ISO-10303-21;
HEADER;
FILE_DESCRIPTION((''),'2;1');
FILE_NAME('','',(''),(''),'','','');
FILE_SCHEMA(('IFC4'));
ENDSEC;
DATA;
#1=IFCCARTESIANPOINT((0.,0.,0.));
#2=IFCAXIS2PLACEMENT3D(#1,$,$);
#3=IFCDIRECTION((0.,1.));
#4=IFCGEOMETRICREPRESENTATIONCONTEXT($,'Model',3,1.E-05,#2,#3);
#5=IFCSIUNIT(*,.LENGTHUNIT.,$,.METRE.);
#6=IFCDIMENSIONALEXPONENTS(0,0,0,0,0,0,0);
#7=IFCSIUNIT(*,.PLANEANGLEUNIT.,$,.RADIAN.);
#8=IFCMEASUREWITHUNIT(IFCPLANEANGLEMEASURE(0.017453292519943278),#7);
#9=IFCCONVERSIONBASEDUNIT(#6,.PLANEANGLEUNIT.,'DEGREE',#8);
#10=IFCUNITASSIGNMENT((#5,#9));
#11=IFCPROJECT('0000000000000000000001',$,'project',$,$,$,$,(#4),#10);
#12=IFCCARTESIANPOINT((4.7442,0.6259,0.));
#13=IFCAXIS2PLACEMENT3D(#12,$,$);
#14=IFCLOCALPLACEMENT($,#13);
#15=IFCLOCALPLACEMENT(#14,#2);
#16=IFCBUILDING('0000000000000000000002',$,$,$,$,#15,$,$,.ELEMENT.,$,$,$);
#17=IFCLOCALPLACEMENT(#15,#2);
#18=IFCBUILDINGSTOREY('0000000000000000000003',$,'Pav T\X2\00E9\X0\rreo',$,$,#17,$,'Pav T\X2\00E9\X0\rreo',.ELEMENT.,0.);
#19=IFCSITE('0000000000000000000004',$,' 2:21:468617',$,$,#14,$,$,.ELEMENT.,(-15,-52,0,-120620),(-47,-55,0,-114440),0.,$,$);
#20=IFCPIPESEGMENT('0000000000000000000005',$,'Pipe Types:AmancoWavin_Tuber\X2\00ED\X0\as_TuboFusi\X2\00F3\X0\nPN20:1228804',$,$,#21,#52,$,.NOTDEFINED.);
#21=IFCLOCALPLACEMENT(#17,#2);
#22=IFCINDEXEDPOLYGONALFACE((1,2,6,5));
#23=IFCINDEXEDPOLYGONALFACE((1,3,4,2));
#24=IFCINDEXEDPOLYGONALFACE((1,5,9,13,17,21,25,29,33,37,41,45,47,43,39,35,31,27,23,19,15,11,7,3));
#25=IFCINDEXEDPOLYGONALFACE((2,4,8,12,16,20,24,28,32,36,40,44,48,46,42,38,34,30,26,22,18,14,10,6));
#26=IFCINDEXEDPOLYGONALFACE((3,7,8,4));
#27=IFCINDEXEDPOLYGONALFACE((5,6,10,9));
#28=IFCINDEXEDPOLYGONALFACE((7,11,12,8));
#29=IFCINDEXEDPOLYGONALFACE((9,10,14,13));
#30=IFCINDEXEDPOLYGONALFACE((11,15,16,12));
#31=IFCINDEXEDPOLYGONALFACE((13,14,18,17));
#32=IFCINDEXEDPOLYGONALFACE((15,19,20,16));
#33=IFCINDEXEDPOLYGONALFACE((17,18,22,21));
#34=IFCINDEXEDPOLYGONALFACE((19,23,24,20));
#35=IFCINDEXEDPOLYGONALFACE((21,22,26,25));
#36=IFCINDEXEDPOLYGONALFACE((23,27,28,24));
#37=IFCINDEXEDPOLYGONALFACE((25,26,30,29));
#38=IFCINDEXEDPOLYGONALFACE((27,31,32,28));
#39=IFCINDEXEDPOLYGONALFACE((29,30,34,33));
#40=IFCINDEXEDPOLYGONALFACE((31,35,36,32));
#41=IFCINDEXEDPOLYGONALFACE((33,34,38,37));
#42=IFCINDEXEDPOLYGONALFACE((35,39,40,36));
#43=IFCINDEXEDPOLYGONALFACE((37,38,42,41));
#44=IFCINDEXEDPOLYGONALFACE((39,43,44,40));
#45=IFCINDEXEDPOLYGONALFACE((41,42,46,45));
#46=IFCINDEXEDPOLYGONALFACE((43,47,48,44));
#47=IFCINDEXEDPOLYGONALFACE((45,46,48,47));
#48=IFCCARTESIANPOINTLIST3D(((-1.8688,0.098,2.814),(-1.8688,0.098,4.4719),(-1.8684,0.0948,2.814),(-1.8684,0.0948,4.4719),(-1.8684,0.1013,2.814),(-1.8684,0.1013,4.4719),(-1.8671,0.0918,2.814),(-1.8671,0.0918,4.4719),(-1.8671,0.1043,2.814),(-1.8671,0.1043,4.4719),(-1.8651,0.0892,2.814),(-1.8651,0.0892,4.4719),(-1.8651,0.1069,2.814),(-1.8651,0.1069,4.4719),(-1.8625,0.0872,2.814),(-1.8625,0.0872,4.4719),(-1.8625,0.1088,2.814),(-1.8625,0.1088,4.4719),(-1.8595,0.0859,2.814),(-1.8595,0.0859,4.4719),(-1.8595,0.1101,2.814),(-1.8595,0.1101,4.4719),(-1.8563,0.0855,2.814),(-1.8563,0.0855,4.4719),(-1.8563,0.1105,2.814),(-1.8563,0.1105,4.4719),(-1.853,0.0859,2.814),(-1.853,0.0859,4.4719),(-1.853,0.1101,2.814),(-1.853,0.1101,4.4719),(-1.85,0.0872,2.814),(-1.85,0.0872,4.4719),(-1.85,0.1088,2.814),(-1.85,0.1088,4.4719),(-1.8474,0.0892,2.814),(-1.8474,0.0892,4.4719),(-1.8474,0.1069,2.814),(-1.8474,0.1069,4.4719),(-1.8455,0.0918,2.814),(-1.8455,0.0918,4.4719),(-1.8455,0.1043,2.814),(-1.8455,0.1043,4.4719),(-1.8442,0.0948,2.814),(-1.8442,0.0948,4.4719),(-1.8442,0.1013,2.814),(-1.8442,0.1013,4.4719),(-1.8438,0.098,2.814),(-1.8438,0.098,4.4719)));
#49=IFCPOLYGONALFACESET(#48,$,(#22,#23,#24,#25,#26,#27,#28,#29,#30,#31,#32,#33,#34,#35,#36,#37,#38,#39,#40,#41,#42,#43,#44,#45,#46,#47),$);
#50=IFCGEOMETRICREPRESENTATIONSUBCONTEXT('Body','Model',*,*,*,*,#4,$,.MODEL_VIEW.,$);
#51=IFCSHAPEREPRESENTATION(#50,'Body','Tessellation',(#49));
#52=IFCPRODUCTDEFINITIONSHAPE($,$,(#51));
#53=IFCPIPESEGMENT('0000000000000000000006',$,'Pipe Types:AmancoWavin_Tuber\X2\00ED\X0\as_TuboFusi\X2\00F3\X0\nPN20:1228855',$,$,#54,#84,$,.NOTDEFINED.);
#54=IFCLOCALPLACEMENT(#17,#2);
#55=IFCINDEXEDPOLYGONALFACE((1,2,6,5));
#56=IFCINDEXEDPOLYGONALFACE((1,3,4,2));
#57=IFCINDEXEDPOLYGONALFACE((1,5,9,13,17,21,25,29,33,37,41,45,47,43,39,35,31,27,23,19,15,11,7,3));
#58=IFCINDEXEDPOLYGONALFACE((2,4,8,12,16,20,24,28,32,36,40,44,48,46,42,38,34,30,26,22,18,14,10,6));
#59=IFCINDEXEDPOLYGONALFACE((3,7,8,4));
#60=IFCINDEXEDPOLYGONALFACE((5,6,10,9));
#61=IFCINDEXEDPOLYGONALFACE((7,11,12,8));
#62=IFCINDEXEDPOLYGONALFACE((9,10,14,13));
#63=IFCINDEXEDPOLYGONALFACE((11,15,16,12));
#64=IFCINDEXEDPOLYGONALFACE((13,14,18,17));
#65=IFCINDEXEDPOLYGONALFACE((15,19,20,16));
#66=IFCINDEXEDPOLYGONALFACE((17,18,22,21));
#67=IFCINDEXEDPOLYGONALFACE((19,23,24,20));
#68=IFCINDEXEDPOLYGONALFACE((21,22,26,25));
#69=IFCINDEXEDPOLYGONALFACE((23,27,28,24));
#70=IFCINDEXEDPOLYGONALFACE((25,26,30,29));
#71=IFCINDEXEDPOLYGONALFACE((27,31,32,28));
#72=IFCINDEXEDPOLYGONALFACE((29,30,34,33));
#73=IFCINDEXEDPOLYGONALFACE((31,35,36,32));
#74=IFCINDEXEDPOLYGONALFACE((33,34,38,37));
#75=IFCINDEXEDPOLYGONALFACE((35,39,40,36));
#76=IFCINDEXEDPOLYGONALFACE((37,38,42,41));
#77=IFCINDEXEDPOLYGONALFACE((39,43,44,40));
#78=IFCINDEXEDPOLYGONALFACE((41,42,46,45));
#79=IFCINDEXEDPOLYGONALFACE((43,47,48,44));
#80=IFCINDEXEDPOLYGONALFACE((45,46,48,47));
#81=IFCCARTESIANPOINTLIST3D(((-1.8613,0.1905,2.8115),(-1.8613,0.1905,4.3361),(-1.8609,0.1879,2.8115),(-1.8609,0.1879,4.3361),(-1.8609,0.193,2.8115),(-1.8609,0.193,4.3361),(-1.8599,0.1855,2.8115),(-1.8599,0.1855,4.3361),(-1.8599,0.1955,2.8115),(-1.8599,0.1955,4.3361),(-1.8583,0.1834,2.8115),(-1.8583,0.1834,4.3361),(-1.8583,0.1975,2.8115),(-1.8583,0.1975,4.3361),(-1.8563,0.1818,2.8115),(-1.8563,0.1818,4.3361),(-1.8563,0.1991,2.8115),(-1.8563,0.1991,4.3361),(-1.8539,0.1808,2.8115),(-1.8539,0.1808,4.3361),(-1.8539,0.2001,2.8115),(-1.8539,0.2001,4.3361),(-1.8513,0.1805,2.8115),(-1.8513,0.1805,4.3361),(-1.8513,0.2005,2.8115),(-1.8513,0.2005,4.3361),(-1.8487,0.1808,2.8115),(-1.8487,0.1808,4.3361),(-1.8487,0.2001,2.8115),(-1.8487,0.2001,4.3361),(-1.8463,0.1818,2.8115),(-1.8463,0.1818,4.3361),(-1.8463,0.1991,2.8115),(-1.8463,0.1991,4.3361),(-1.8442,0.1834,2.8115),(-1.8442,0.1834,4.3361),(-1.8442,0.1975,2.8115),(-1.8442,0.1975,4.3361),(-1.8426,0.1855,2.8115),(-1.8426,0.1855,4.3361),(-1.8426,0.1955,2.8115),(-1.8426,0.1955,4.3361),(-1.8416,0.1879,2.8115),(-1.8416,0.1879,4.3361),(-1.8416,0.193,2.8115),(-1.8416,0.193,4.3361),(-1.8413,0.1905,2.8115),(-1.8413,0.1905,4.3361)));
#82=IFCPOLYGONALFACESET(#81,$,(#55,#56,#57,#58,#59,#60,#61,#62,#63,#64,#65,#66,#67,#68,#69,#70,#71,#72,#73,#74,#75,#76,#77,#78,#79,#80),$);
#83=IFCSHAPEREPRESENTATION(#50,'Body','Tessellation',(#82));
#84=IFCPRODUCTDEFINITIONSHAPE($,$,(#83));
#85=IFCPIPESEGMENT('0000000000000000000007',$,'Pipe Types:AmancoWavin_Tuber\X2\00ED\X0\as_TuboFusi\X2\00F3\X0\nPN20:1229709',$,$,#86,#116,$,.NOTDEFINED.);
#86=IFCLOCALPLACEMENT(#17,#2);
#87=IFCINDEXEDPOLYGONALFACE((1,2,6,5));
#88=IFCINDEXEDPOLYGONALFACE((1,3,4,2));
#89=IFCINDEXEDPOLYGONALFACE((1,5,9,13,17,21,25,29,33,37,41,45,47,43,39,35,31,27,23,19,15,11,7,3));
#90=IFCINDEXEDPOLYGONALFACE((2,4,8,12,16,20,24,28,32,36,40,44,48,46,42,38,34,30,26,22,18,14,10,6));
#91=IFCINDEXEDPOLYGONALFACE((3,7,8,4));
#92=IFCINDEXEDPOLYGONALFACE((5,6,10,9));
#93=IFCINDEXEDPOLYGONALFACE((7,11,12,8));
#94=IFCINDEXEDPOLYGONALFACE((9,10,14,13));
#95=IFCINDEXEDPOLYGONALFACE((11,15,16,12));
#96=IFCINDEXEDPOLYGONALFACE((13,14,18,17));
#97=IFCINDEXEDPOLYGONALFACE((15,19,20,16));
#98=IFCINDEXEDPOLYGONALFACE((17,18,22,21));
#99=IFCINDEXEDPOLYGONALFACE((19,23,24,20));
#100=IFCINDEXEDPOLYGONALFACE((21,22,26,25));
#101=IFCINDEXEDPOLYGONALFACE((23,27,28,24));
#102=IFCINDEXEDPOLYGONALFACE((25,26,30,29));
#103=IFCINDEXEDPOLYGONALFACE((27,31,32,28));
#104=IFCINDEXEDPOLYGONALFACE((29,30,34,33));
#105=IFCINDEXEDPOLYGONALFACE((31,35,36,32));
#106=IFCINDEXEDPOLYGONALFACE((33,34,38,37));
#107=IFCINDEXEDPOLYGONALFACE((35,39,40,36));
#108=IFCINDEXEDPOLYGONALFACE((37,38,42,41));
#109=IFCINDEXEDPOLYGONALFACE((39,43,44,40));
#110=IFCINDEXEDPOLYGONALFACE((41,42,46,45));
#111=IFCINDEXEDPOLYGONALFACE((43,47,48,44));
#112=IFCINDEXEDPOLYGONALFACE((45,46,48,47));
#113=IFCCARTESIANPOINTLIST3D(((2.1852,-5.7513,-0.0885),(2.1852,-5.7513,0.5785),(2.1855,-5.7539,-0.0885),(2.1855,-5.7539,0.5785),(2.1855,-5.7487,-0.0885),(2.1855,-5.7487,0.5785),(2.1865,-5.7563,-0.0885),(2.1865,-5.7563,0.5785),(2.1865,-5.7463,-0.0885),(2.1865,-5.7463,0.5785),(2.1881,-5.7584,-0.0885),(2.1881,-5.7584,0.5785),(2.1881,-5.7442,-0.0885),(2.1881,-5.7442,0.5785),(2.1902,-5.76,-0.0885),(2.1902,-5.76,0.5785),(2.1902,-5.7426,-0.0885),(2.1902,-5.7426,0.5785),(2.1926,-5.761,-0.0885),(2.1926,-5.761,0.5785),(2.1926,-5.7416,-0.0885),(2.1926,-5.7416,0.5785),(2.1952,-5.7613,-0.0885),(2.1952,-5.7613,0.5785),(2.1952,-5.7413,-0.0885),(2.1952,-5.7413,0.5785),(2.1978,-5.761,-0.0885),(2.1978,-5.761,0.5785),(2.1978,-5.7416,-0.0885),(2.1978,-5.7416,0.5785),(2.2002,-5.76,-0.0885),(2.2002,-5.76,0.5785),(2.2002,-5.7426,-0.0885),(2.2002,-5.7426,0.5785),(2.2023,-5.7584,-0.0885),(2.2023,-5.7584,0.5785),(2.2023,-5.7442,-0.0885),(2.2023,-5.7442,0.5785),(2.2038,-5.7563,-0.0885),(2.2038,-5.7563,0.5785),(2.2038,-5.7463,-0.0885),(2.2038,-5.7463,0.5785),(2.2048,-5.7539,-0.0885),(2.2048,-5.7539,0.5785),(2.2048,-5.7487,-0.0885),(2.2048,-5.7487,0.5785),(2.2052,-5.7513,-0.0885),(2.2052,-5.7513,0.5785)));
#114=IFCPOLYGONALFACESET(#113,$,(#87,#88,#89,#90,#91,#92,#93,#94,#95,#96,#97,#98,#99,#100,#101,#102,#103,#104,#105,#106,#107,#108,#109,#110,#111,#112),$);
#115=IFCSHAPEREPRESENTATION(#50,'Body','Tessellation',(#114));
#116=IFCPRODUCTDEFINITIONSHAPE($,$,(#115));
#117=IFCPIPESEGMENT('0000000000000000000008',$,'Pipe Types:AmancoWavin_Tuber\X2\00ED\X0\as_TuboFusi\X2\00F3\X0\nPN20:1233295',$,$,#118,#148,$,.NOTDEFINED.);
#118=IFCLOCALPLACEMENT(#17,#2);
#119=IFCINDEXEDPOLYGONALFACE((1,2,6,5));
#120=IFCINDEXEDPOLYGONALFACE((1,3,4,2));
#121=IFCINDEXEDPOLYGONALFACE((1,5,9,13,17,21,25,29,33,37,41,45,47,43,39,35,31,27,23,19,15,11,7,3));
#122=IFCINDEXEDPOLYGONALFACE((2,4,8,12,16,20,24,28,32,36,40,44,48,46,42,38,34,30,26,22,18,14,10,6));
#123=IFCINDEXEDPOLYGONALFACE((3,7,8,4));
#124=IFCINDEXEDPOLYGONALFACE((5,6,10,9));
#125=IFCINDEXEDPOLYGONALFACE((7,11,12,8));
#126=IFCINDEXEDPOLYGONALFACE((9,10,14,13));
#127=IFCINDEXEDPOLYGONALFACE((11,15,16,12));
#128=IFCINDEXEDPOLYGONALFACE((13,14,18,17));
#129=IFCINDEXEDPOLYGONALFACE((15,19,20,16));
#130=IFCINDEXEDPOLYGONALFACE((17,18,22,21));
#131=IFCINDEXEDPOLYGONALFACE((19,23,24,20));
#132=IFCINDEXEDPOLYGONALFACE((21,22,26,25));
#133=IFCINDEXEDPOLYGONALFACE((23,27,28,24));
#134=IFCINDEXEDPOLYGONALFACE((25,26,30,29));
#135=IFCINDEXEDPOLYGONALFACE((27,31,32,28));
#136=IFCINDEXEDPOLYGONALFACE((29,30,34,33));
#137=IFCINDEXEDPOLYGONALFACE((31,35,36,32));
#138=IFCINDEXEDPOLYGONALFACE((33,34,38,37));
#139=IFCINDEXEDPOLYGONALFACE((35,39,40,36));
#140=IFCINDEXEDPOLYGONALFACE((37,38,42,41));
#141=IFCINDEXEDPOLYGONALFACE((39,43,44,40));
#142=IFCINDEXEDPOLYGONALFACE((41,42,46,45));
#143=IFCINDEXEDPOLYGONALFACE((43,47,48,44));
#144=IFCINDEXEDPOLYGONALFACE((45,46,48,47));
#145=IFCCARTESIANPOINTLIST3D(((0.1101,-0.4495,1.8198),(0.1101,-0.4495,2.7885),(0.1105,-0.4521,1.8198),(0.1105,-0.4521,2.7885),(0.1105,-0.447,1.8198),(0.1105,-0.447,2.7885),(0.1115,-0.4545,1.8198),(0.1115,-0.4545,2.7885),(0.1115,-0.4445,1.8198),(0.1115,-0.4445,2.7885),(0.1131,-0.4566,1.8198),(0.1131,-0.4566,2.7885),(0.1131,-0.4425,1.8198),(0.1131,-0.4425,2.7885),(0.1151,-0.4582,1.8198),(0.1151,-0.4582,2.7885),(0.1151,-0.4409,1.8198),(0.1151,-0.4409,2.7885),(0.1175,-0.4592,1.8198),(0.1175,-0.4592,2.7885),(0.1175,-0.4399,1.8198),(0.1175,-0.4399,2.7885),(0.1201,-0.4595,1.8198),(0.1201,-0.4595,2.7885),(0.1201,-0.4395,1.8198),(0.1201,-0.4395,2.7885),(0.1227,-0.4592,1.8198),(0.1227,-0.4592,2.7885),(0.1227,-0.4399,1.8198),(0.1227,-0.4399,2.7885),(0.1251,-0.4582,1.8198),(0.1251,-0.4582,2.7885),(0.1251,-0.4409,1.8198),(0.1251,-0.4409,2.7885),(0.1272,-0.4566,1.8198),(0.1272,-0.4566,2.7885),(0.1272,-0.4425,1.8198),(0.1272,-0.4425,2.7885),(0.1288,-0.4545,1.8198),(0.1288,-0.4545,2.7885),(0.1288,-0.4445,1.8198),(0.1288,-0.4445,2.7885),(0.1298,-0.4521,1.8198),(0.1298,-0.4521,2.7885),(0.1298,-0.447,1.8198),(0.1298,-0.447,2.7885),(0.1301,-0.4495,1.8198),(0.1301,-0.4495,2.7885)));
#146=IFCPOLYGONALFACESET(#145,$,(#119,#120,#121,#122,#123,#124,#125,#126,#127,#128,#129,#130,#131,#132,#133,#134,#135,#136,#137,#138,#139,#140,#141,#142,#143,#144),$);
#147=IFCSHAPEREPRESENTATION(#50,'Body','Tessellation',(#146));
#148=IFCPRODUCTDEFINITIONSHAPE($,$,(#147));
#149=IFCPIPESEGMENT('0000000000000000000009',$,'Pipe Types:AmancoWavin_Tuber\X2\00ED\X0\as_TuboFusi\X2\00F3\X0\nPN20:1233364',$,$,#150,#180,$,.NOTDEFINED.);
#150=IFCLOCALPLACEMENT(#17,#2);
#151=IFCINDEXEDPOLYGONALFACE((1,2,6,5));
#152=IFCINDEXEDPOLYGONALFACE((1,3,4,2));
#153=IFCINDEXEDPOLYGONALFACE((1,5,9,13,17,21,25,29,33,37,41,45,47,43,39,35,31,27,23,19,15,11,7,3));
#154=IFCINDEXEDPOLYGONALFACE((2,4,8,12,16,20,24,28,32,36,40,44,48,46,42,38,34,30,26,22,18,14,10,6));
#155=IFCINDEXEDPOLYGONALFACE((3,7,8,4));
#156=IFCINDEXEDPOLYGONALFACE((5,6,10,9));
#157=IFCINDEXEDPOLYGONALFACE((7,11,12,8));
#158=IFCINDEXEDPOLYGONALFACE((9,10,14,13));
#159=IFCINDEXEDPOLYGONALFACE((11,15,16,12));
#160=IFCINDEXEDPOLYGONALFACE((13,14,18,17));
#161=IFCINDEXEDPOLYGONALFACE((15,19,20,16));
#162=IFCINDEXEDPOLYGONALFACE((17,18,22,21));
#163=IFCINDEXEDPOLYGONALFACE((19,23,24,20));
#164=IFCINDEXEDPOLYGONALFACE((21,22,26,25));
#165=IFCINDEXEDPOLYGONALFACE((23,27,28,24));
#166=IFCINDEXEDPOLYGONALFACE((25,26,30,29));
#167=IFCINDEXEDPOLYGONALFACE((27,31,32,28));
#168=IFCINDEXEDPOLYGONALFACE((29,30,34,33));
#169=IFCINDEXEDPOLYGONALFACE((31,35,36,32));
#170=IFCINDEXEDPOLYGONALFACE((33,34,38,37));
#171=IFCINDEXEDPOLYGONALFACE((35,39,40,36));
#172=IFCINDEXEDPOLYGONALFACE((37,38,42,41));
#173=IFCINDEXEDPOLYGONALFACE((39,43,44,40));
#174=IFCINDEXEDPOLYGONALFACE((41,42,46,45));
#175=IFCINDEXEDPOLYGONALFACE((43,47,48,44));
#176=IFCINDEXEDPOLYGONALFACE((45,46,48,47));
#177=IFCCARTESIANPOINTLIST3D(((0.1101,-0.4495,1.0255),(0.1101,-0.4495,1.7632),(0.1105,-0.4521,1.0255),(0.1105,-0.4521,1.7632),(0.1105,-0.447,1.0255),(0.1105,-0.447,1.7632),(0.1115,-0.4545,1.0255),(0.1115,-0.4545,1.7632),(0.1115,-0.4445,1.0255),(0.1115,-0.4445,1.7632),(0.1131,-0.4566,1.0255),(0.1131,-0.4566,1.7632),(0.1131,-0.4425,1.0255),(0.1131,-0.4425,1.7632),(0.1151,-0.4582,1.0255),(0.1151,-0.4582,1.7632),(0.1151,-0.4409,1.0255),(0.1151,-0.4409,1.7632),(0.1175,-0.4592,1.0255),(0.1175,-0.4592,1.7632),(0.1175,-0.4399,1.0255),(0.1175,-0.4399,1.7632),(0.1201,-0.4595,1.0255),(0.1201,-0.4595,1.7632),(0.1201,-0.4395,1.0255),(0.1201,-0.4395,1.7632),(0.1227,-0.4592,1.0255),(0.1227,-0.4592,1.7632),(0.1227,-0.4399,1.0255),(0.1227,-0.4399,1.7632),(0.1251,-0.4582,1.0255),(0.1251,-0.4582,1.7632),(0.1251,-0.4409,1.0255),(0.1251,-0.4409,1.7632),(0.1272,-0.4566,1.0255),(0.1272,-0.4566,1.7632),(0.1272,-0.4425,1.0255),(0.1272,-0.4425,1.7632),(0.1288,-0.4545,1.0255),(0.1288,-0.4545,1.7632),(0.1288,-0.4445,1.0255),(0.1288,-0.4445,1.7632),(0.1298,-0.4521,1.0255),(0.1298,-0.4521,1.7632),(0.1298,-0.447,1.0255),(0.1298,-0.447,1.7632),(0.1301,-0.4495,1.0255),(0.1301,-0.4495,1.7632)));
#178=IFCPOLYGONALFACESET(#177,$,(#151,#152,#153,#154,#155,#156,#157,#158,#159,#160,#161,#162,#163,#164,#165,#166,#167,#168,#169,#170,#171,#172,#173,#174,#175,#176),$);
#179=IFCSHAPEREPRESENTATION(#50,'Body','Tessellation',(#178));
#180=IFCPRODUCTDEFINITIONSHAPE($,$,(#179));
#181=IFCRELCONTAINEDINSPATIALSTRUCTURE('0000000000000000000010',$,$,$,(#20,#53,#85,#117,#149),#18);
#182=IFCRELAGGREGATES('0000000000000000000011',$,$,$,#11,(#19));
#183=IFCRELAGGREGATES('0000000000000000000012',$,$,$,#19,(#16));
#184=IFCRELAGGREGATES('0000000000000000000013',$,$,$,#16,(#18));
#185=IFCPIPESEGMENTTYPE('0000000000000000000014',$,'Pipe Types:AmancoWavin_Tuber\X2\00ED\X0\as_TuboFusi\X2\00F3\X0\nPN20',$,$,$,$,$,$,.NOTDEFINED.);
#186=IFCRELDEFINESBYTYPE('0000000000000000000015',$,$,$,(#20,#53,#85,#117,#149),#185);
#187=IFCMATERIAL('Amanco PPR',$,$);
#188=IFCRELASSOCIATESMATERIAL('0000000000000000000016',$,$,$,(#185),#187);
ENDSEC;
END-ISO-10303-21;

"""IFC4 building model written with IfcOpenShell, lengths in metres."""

from ifc_helpers import new_model, entity, si_unit, converted_unit, direction, frame, origin, place, context, subcontext, project, spatial, arc, indexed_curve, outline, extrude, material, type_object, element, save


model = new_model("IFC4")

# Units and contexts
model_context = context("Model", 3, precision=1e-05, world=origin(), true_north=direction((0.0, 1.0)))
body_context = subcontext(model_context, "Body", "Model", "MODEL_VIEW")
ifc_project = project(units=[si_unit("LENGTHUNIT", "METRE"), converted_unit("PLANEANGLEUNIT", "DEGREE", entity("IfcPlaneAngleMeasure", 0.017453292519943278), si_unit("PLANEANGLEUNIT", "RADIAN"), dimensions=[0, 0, 0, 0, 0, 0, 0])], contexts=[model_context])

# Site, building, storey
site_placement = place(None, frame((4.7442, 0.6259, 0.0)))
site = spatial("IfcSite", under=ifc_project, at=site_placement, Name=" 2:21:468617", CompositionType="ELEMENT", RefLatitude=(-15, -52, 0, -120620), RefLongitude=(-47, -55, 0, -114440), RefElevation=0.0)
building_placement = place(site_placement, origin())
building = spatial("IfcBuilding", under=site, at=building_placement, CompositionType="ELEMENT")
storey_placement = place(building_placement, origin())
storey = spatial("IfcBuildingStorey", under=building, at=storey_placement, Name="Pav Térreo", LongName="Pav Térreo", CompositionType="ELEMENT", Elevation=0.0)

# Pipe segments
ifc_material_1 = material(Name="Amanco PPR")
pipe_segment_type_1 = type_object("IfcPipeSegmentType", Name="Pipe Types:AmancoWavin_Tuberías_TuboFusiónPN20", PredefinedType="NOTDEFINED", material=ifc_material_1)
pipe_segment_1_placement = place(storey_placement, origin())
element("IfcPipeSegment", 1, at=pipe_segment_1_placement, inside=storey, type_object=pipe_segment_type_1, Name="Pipe Types:AmancoWavin_Tuberías_TuboFusiónPN20:1228804", PredefinedType="NOTDEFINED", context=body_context, shape_type="SweptSolid", body=[
    extrude(outline(indexed_curve([(0.0125, 0.0), (0.0088, 0.0088), (0.0, 0.0125), (-0.0088, 0.0088), (-0.0125, 0.0), (-0.0088, -0.0088), (0.0, -0.0125), (0.0088, -0.0088)], segments=[arc(1, 2, 3), arc(3, 4, 5), arc(5, 6, 7), arc(7, 8, 1)], self_intersect=False)), frame((-1.8563, 0.098, 2.814)), (0.0, 0.0, 1.0), 1.6579),
])
pipe_segment_2_placement = place(storey_placement, origin())
element("IfcPipeSegment", 2, at=pipe_segment_2_placement, inside=storey, type_object=pipe_segment_type_1, Name="Pipe Types:AmancoWavin_Tuberías_TuboFusiónPN20:1228855", PredefinedType="NOTDEFINED", context=body_context, shape_type="SweptSolid", body=[
    extrude(outline(indexed_curve([(0.01, 0.0), (0.0071, 0.0071), (0.0, 0.01), (-0.0071, 0.0071), (-0.01, 0.0), (-0.0071, -0.0071), (0.0, -0.01), (0.0071, -0.0071)], segments=[arc(1, 2, 3), arc(3, 4, 5), arc(5, 6, 7), arc(7, 8, 1)], self_intersect=False)), frame((-1.8513, 0.1905, 2.8115), z_axis=(0.0, 0.0, 1.0), x_axis=(-1.0, 0.0, 0.0)), (0.0, 0.0, 1.0), 1.5246),
])
pipe_segment_3_placement = place(storey_placement, origin())
element("IfcPipeSegment", 3, at=pipe_segment_3_placement, inside=storey, type_object=pipe_segment_type_1, Name="Pipe Types:AmancoWavin_Tuberías_TuboFusiónPN20:1229709", PredefinedType="NOTDEFINED", context=body_context, shape_type="SweptSolid", body=[
    extrude(outline(indexed_curve([(0.01, 0.0), (0.0071, 0.0071), (0.0, 0.01), (-0.0071, 0.0071), (-0.01, 0.0), (-0.0071, -0.0071), (0.0, -0.01), (0.0071, -0.0071)], segments=[arc(1, 2, 3), arc(3, 4, 5), arc(5, 6, 7), arc(7, 8, 1)], self_intersect=False)), frame((2.1952, -5.7513, -0.0885), z_axis=(0.0, 0.0, 1.0), x_axis=(-1.0, 0.0, 0.0)), (0.0, 0.0, 1.0), 0.667),
])
pipe_segment_4_placement = place(storey_placement, origin())
element("IfcPipeSegment", 4, at=pipe_segment_4_placement, inside=storey, type_object=pipe_segment_type_1, Name="Pipe Types:AmancoWavin_Tuberías_TuboFusiónPN20:1233295", PredefinedType="NOTDEFINED", context=body_context, shape_type="SweptSolid", body=[
    extrude(outline(indexed_curve([(0.01, 0.0), (0.0071, 0.0071), (0.0, 0.01), (-0.0071, 0.0071), (-0.01, 0.0), (-0.0071, -0.0071), (0.0, -0.01), (0.0071, -0.0071)], segments=[arc(1, 2, 3), arc(3, 4, 5), arc(5, 6, 7), arc(7, 8, 1)], self_intersect=False)), frame((0.1201, -0.4495, 1.8198)), (0.0, 0.0, 1.0), 0.9687),
])
pipe_segment_5_placement = place(storey_placement, origin())
element("IfcPipeSegment", 5, at=pipe_segment_5_placement, inside=storey, type_object=pipe_segment_type_1, Name="Pipe Types:AmancoWavin_Tuberías_TuboFusiónPN20:1233364", PredefinedType="NOTDEFINED", context=body_context, shape_type="SweptSolid", body=[
    extrude(outline(indexed_curve([(0.01, 0.0), (0.0071, 0.0071), (0.0, 0.01), (-0.0071, 0.0071), (-0.01, 0.0), (-0.0071, -0.0071), (0.0, -0.01), (0.0071, -0.0071)], segments=[arc(1, 2, 3), arc(3, 4, 5), arc(5, 6, 7), arc(7, 8, 1)], self_intersect=False)), frame((0.1201, -0.4495, 1.0255)), (0.0, 0.0, 1.0), 0.7377),
])

save(model, "model.ifc")
